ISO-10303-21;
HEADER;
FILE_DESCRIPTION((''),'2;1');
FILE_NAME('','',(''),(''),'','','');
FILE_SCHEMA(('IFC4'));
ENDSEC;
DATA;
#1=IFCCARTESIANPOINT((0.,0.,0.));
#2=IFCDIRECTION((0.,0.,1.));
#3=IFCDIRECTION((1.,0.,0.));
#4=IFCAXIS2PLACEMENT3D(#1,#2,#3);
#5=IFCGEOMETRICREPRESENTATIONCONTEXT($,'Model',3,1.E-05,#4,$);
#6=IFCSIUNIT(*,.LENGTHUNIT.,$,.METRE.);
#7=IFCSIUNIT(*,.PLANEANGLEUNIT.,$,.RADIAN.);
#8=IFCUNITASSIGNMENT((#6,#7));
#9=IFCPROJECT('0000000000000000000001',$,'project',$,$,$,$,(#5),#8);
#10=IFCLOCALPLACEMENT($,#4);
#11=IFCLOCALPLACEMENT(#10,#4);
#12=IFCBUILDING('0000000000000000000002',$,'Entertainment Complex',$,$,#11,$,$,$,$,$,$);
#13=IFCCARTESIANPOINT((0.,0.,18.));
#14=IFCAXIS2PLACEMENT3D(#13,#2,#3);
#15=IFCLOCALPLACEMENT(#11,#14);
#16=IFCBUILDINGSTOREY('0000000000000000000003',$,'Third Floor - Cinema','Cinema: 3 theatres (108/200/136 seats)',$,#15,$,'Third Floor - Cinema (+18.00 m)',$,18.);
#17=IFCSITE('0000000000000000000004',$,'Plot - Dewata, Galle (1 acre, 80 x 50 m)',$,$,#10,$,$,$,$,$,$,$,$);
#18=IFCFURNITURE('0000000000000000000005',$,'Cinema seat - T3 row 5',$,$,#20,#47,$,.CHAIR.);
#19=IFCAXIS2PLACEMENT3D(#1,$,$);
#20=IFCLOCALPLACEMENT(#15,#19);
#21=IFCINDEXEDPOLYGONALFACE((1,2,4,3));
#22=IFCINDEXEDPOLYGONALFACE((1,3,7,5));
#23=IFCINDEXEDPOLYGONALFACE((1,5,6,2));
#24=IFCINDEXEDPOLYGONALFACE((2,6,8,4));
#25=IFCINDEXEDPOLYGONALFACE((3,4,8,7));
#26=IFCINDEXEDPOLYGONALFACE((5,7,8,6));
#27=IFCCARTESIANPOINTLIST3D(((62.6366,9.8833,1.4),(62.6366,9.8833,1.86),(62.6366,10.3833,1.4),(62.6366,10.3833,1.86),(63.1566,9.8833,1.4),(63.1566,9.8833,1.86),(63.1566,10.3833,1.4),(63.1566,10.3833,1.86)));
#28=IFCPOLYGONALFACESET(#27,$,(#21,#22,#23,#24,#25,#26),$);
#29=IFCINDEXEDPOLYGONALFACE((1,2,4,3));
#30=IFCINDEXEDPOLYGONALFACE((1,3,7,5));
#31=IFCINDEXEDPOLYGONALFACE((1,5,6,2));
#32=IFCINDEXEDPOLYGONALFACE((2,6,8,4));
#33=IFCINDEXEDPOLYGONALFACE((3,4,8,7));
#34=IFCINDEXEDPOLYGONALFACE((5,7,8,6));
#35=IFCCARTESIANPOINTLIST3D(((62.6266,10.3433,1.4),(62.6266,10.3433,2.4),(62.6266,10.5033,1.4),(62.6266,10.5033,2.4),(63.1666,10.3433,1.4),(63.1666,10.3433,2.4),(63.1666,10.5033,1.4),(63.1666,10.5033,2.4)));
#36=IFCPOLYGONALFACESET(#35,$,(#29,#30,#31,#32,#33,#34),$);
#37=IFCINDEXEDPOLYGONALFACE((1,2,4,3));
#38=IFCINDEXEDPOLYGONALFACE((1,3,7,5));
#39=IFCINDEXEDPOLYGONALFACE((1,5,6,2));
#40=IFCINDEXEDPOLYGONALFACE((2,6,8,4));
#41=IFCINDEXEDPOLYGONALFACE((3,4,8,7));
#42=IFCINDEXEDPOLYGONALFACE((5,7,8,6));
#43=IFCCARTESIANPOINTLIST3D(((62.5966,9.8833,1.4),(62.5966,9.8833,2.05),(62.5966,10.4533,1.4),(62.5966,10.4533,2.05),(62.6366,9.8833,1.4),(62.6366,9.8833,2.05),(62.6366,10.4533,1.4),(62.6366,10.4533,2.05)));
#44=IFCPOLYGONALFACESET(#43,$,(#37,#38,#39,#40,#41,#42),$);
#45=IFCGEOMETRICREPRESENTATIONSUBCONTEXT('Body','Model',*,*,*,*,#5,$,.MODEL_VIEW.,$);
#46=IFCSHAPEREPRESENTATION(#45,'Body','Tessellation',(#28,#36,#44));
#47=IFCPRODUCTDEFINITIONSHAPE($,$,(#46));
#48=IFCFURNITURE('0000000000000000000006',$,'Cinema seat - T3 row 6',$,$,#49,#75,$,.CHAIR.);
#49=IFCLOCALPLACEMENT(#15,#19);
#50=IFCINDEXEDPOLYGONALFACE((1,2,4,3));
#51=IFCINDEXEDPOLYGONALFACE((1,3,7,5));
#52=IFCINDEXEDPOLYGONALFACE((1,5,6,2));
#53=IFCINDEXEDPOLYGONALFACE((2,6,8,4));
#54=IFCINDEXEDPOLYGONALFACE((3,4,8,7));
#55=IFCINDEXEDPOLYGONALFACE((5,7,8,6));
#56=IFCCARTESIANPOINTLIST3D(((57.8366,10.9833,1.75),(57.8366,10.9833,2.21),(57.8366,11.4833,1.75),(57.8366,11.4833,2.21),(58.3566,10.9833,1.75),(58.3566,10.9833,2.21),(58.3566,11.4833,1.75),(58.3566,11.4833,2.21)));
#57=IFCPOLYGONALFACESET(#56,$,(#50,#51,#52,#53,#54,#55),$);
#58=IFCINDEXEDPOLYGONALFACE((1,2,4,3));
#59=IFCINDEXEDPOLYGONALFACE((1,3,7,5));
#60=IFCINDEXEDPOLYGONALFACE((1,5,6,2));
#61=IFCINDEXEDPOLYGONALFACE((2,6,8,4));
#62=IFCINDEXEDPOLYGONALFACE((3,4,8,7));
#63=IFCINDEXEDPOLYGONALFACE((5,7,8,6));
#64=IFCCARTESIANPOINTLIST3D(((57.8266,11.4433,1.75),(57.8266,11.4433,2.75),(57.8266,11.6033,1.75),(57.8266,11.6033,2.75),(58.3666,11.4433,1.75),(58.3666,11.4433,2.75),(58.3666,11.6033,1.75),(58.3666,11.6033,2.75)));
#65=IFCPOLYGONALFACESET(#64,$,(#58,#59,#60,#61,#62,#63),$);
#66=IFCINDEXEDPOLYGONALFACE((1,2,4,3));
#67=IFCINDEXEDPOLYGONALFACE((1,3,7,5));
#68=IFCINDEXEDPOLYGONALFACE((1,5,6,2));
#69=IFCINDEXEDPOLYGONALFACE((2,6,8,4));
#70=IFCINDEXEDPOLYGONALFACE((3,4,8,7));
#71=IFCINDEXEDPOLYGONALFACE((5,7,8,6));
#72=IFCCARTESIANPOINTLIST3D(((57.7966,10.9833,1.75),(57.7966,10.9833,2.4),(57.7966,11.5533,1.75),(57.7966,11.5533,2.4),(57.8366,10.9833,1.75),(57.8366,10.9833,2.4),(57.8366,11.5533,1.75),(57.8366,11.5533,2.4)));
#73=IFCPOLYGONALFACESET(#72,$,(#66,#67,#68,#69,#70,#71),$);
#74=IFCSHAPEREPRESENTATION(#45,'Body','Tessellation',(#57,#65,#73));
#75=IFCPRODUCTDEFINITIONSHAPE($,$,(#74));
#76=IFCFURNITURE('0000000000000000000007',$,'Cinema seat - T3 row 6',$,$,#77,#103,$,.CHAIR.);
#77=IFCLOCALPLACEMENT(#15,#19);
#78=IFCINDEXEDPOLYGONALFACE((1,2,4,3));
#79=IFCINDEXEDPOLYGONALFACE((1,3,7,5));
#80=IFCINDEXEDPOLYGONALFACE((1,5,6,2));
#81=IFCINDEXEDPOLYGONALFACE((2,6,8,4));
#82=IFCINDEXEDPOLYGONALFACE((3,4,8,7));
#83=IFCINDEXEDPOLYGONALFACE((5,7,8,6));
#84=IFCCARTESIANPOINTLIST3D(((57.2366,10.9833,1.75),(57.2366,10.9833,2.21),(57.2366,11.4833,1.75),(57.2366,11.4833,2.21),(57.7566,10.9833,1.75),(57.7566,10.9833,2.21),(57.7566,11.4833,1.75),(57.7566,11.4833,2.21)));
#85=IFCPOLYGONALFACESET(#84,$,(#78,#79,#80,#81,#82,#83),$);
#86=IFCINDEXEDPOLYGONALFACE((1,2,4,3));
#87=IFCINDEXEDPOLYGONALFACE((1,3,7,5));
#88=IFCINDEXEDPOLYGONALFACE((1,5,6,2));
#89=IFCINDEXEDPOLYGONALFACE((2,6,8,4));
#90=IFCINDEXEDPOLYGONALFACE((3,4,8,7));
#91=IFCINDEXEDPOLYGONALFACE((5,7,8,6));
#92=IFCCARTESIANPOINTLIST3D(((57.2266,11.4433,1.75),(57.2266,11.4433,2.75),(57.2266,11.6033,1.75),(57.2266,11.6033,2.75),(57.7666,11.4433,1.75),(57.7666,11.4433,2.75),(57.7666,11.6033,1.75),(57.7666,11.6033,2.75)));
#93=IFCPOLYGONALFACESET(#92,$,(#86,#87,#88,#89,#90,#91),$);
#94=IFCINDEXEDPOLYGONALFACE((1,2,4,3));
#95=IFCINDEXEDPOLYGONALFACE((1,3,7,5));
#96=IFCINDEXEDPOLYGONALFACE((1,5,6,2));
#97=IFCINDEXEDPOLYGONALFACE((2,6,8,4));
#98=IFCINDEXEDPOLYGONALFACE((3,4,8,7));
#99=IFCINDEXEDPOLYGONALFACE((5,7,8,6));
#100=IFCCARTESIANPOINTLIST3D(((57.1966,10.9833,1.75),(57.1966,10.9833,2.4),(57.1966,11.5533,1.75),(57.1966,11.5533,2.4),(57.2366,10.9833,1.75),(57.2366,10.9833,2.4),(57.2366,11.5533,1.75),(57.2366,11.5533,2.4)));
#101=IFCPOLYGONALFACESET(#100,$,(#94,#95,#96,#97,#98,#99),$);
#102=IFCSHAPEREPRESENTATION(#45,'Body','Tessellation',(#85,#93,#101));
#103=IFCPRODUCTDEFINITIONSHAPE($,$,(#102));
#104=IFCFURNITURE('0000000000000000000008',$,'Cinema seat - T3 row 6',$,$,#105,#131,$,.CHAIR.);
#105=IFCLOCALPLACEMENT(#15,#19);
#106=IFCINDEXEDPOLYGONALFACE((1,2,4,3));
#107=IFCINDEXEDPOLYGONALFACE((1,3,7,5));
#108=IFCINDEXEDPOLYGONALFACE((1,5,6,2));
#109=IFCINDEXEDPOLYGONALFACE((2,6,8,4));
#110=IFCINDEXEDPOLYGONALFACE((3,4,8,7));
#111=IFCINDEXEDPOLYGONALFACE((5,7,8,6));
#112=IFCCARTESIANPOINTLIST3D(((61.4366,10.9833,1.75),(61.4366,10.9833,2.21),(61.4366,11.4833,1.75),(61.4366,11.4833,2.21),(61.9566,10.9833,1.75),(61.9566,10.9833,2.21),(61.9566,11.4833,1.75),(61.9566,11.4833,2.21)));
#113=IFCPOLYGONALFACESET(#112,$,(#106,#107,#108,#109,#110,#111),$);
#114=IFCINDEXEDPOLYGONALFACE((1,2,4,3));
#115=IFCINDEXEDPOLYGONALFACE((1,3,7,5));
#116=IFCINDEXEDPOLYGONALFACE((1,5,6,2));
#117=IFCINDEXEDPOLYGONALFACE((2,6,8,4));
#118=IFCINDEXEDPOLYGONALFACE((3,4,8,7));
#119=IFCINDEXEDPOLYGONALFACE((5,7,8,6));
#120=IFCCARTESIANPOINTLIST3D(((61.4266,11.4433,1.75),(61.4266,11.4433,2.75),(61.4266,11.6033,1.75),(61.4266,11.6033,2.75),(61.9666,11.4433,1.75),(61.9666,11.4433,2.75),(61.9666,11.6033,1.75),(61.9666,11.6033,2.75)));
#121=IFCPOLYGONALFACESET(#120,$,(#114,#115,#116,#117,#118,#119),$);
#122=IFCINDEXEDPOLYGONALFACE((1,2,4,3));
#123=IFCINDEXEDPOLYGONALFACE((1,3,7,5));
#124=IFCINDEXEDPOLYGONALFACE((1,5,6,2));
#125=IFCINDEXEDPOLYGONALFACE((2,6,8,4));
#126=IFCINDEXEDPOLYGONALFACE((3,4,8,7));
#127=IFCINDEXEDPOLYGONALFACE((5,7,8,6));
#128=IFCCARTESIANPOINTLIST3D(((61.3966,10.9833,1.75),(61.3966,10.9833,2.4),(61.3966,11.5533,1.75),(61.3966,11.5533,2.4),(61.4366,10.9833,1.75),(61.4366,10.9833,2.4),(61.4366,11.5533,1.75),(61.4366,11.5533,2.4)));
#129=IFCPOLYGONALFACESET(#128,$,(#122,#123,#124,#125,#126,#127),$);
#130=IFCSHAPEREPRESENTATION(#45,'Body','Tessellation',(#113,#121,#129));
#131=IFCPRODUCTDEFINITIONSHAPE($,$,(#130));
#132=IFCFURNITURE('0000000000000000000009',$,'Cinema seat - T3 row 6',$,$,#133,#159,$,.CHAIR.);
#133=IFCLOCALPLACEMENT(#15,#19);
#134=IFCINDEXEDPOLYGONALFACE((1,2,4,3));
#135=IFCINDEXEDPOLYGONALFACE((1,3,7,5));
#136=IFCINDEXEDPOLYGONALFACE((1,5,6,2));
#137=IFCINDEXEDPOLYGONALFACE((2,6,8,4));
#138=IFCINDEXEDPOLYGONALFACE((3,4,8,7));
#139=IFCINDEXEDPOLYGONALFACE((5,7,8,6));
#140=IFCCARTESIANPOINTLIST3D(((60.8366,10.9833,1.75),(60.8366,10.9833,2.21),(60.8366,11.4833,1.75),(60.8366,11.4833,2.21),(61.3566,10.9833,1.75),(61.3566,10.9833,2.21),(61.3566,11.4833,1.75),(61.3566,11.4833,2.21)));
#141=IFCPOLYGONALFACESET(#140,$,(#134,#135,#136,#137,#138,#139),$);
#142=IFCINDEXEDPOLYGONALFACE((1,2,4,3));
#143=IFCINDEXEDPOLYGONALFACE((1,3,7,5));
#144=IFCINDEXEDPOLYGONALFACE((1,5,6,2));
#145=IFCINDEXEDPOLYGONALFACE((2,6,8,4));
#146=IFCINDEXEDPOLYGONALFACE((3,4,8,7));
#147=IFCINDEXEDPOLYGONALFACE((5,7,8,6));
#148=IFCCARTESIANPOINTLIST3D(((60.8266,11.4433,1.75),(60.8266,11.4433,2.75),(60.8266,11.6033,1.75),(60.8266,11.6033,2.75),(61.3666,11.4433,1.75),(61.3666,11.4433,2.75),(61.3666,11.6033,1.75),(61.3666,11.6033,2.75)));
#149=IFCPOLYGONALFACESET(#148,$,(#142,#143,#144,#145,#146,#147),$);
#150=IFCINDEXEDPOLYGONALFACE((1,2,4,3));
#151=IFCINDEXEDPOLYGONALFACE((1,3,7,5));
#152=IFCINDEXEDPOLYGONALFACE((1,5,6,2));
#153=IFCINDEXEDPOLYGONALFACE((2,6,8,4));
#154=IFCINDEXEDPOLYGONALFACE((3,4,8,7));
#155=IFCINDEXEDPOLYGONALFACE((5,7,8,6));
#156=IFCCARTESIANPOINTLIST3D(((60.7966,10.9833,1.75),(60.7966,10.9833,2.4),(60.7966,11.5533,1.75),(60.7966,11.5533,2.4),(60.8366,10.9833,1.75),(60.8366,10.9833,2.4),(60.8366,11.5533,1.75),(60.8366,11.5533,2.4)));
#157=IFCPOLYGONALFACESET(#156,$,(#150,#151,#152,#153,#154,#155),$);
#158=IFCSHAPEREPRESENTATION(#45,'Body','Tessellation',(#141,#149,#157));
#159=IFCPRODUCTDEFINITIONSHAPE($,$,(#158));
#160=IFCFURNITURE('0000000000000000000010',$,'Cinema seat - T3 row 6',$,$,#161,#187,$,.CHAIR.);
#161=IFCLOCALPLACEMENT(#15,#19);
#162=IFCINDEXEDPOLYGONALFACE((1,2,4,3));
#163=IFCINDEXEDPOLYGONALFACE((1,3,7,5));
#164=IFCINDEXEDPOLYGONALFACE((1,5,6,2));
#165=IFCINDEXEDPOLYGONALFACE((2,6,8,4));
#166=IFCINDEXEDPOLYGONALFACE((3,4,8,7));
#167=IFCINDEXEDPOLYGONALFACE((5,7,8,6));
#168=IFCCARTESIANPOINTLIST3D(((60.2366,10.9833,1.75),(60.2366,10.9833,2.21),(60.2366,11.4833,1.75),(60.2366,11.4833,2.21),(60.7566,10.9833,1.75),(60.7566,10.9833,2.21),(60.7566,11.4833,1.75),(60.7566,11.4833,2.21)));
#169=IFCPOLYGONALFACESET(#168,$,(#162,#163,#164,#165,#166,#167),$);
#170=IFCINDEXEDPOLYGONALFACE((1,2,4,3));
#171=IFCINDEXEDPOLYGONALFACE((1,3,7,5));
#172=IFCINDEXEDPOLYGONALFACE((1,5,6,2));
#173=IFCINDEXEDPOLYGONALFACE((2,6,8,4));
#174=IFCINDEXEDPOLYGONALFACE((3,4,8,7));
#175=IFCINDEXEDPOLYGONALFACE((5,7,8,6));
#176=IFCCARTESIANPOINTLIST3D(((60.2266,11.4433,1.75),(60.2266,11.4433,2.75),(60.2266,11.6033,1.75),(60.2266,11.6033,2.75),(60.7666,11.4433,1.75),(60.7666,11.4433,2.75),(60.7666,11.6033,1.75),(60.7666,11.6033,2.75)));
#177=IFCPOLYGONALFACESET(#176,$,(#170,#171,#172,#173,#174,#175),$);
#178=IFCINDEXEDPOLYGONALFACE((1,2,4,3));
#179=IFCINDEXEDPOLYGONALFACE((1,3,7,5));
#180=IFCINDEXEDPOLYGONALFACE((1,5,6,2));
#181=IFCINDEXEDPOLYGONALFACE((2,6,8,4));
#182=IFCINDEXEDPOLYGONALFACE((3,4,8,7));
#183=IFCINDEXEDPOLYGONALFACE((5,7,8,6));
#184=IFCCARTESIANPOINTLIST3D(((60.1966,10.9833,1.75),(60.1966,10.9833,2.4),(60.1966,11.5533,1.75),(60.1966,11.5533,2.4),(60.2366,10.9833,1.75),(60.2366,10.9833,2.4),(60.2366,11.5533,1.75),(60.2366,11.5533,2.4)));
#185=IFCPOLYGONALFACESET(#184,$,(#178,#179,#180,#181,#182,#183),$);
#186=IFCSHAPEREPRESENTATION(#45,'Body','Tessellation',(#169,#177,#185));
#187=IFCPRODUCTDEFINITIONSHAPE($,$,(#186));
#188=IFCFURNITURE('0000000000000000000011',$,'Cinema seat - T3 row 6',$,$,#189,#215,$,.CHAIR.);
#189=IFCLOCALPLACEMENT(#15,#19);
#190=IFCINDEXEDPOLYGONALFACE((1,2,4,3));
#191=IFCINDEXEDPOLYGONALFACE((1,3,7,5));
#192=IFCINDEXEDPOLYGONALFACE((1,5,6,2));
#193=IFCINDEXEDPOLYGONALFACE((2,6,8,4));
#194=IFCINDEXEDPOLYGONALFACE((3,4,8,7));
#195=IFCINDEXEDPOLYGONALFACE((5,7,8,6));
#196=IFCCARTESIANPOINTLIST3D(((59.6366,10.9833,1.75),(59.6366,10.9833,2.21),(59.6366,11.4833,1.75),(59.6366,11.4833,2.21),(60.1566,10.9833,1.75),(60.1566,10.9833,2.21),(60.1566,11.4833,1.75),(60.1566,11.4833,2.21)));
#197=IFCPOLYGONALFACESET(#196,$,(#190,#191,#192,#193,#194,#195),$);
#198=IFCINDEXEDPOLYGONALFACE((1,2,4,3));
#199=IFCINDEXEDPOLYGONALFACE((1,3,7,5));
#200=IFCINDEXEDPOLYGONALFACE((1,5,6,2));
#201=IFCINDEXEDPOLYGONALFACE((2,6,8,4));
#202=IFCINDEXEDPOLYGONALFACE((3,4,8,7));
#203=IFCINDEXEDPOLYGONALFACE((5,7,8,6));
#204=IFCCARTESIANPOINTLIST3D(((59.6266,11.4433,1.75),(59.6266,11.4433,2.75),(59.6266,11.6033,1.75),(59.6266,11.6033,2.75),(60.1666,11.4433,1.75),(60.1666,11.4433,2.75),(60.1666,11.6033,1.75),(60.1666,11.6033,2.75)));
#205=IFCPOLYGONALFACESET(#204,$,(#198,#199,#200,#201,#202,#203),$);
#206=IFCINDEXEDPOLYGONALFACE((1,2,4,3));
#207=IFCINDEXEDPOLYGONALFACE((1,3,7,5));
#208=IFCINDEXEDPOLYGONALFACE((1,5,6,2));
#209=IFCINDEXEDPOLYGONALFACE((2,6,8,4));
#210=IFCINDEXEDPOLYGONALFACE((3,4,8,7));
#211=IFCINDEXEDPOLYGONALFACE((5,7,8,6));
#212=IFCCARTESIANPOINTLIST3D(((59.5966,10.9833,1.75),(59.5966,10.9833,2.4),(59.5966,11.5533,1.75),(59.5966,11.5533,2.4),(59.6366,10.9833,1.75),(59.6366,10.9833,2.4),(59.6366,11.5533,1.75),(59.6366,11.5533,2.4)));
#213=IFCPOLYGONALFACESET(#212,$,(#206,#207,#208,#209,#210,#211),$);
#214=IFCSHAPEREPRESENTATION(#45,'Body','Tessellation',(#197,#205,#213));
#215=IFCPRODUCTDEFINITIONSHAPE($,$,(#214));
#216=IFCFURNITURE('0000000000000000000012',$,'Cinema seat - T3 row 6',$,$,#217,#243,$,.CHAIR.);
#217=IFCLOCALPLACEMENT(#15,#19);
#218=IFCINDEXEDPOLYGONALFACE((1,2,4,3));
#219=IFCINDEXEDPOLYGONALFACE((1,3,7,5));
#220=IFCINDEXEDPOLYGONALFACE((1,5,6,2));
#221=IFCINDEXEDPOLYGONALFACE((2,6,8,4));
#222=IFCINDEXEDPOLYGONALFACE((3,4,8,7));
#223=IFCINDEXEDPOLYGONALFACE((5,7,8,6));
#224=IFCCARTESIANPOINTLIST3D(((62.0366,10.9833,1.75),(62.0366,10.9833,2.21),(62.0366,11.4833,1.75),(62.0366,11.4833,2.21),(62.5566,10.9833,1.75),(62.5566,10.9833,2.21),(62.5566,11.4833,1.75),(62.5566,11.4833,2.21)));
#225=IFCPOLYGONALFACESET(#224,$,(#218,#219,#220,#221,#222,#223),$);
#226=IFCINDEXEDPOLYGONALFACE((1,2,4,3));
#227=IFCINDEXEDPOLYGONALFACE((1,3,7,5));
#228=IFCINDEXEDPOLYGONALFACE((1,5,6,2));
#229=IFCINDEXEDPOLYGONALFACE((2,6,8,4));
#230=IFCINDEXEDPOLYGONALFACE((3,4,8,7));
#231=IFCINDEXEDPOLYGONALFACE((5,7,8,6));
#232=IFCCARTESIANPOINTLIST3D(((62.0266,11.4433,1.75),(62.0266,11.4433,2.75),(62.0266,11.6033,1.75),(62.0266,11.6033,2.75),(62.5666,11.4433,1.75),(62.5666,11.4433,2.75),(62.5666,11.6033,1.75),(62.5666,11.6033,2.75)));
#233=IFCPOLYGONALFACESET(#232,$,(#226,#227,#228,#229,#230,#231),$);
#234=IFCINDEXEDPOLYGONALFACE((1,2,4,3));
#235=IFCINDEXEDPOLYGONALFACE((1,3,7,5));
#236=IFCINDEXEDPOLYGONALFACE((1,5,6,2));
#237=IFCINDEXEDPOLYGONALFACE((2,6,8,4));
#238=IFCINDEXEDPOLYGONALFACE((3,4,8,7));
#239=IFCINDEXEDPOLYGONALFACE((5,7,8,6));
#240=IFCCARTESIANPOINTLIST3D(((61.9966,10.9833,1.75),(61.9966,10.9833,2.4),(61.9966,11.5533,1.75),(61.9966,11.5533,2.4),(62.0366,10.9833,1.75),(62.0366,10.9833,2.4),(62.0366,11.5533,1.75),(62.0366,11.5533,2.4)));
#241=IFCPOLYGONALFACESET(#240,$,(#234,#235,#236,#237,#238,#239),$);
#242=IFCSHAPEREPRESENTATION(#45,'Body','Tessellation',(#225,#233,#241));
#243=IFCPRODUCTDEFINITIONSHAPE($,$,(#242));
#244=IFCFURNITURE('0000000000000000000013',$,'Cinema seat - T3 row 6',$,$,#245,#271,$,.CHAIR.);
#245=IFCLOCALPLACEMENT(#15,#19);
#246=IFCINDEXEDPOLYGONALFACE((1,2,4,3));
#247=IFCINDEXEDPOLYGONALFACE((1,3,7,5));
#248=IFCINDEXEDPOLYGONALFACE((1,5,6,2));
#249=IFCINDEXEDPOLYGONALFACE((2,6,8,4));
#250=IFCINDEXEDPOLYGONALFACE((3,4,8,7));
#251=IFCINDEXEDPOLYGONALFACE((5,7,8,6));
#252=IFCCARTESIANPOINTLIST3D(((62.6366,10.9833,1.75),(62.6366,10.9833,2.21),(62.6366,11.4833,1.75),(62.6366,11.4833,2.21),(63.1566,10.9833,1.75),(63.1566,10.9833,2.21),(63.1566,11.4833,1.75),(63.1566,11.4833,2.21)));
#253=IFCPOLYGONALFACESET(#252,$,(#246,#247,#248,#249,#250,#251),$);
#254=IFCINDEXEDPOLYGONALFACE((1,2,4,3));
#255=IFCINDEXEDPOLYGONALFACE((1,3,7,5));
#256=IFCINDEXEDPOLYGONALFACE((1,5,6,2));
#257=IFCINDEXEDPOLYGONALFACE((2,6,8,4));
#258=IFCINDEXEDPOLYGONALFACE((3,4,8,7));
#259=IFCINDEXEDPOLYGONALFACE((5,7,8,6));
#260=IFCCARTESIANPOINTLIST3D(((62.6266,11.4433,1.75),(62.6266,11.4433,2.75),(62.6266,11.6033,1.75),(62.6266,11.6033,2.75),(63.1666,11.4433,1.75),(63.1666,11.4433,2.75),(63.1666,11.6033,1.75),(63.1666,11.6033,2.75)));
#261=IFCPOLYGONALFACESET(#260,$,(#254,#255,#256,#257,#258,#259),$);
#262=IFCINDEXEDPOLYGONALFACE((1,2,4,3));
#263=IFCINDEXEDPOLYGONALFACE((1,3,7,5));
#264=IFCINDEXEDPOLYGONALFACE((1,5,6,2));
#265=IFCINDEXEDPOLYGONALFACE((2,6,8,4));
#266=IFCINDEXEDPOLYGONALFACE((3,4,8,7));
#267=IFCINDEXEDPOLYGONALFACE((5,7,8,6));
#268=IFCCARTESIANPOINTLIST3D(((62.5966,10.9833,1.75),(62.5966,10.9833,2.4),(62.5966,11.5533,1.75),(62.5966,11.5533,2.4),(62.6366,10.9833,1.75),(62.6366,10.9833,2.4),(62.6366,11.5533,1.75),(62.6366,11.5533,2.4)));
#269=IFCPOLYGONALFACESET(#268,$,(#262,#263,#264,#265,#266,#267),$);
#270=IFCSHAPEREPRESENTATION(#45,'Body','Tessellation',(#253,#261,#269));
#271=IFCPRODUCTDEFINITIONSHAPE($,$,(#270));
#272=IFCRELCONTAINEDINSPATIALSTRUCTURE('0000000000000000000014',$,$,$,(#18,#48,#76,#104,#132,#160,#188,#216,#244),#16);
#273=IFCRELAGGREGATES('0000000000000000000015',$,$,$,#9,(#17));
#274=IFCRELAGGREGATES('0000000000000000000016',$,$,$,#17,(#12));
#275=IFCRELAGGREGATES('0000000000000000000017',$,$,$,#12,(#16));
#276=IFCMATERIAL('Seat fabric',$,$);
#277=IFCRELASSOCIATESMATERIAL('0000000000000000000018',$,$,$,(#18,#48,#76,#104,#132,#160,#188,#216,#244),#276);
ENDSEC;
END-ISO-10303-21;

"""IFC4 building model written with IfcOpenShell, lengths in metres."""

from ifc_helpers import new_model, si_unit, frame, origin_with_axes, place, context, subcontext, project, spatial, polyline, outline, extrude, material, element, save


model = new_model("IFC4")

# Units and contexts
model_context = context("Model", 3, precision=1e-05, world=origin_with_axes())
body_context = subcontext(model_context, "Body", "Model", "MODEL_VIEW")
ifc_project = project(units=[si_unit("LENGTHUNIT", "METRE"), si_unit("PLANEANGLEUNIT", "RADIAN")], contexts=[model_context])

# Site, building, storey
site_placement = place(None, origin_with_axes())
site = spatial("IfcSite", under=ifc_project, at=site_placement, Name="Plot - Dewata, Galle (1 acre, 80 x 50 m)")
building_placement = place(site_placement, origin_with_axes())
building = spatial("IfcBuilding", under=site, at=building_placement, Name="Entertainment Complex")
storey_placement = place(building_placement, frame((0.0, 0.0, 18.0), z_axis=(0.0, 0.0, 1.0), x_axis=(1.0, 0.0, 0.0)))
storey = spatial("IfcBuildingStorey", under=building, at=storey_placement, Name="Third Floor - Cinema", Description="Cinema: 3 theatres (108/200/136 seats)", LongName="Third Floor - Cinema (+18.00 m)", Elevation=18.0)

# Furniture
ifc_material_1 = material(Name="Seat fabric")
for number, where, z_axis, x_axis, name in (
    (1, (62.8966, 10.5033, 1.4), (0.0, 0.0, 1.0), (0.0, 1.0, 0.0), "Cinema seat - T3 row 5"),
    (2, (58.0966, 11.6033, 1.75), (0.0, 0.0, 1.0), (0.0, 1.0, 0.0), "Cinema seat - T3 row 6"),
    (3, (57.4966, 11.6033, 1.75), (0.0, 0.0, 1.0), (0.0, 1.0, 0.0), "Cinema seat - T3 row 6"),
    (4, (61.6966, 11.6033, 1.75), (0.0, 0.0, 1.0), (0.0, 1.0, 0.0), "Cinema seat - T3 row 6"),
    (5, (61.0966, 11.6033, 1.75), (0.0, 0.0, 1.0), (0.0, 1.0, 0.0), "Cinema seat - T3 row 6"),
    (6, (60.4966, 11.6033, 1.75), (0.0, 0.0, 1.0), (0.0, 1.0, 0.0), "Cinema seat - T3 row 6"),
    (7, (59.8966, 11.6033, 1.75), (0.0, 0.0, 1.0), (0.0, 1.0, 0.0), "Cinema seat - T3 row 6"),
    (8, (62.2966, 11.6033, 1.75), (0.0, 0.0, 1.0), (0.0, 1.0, 0.0), "Cinema seat - T3 row 6"),
    (9, (62.8966, 11.6033, 1.75), (0.0, 0.0, 1.0), (0.0, 1.0, 0.0), "Cinema seat - T3 row 6"),
):
    element("IfcFurniture", number, at=place(storey_placement, frame(where, z_axis=z_axis, x_axis=x_axis)), inside=storey, material=ifc_material_1, Name=name, PredefinedType="CHAIR", context=body_context, shape_type="SweptSolid", body=[
        extrude(outline(polyline([(-0.62, -0.26), (-0.12, -0.26), (-0.12, 0.26), (-0.62, 0.26), (-0.62, -0.26)])), origin_with_axes(), (0.0, 0.0, 1.0), 0.46),
        extrude(outline(polyline([(-0.16, -0.27), (0.0, -0.27), (0.0, 0.27), (-0.16, 0.27), (-0.16, -0.27)])), origin_with_axes(), (0.0, 0.0, 1.0), 1.0),
        extrude(outline(polyline([(-0.62, 0.26), (-0.05, 0.26), (-0.05, 0.3), (-0.62, 0.3), (-0.62, 0.26)])), origin_with_axes(), (0.0, 0.0, 1.0), 0.65),
    ])

save(model, "model.ifc")
